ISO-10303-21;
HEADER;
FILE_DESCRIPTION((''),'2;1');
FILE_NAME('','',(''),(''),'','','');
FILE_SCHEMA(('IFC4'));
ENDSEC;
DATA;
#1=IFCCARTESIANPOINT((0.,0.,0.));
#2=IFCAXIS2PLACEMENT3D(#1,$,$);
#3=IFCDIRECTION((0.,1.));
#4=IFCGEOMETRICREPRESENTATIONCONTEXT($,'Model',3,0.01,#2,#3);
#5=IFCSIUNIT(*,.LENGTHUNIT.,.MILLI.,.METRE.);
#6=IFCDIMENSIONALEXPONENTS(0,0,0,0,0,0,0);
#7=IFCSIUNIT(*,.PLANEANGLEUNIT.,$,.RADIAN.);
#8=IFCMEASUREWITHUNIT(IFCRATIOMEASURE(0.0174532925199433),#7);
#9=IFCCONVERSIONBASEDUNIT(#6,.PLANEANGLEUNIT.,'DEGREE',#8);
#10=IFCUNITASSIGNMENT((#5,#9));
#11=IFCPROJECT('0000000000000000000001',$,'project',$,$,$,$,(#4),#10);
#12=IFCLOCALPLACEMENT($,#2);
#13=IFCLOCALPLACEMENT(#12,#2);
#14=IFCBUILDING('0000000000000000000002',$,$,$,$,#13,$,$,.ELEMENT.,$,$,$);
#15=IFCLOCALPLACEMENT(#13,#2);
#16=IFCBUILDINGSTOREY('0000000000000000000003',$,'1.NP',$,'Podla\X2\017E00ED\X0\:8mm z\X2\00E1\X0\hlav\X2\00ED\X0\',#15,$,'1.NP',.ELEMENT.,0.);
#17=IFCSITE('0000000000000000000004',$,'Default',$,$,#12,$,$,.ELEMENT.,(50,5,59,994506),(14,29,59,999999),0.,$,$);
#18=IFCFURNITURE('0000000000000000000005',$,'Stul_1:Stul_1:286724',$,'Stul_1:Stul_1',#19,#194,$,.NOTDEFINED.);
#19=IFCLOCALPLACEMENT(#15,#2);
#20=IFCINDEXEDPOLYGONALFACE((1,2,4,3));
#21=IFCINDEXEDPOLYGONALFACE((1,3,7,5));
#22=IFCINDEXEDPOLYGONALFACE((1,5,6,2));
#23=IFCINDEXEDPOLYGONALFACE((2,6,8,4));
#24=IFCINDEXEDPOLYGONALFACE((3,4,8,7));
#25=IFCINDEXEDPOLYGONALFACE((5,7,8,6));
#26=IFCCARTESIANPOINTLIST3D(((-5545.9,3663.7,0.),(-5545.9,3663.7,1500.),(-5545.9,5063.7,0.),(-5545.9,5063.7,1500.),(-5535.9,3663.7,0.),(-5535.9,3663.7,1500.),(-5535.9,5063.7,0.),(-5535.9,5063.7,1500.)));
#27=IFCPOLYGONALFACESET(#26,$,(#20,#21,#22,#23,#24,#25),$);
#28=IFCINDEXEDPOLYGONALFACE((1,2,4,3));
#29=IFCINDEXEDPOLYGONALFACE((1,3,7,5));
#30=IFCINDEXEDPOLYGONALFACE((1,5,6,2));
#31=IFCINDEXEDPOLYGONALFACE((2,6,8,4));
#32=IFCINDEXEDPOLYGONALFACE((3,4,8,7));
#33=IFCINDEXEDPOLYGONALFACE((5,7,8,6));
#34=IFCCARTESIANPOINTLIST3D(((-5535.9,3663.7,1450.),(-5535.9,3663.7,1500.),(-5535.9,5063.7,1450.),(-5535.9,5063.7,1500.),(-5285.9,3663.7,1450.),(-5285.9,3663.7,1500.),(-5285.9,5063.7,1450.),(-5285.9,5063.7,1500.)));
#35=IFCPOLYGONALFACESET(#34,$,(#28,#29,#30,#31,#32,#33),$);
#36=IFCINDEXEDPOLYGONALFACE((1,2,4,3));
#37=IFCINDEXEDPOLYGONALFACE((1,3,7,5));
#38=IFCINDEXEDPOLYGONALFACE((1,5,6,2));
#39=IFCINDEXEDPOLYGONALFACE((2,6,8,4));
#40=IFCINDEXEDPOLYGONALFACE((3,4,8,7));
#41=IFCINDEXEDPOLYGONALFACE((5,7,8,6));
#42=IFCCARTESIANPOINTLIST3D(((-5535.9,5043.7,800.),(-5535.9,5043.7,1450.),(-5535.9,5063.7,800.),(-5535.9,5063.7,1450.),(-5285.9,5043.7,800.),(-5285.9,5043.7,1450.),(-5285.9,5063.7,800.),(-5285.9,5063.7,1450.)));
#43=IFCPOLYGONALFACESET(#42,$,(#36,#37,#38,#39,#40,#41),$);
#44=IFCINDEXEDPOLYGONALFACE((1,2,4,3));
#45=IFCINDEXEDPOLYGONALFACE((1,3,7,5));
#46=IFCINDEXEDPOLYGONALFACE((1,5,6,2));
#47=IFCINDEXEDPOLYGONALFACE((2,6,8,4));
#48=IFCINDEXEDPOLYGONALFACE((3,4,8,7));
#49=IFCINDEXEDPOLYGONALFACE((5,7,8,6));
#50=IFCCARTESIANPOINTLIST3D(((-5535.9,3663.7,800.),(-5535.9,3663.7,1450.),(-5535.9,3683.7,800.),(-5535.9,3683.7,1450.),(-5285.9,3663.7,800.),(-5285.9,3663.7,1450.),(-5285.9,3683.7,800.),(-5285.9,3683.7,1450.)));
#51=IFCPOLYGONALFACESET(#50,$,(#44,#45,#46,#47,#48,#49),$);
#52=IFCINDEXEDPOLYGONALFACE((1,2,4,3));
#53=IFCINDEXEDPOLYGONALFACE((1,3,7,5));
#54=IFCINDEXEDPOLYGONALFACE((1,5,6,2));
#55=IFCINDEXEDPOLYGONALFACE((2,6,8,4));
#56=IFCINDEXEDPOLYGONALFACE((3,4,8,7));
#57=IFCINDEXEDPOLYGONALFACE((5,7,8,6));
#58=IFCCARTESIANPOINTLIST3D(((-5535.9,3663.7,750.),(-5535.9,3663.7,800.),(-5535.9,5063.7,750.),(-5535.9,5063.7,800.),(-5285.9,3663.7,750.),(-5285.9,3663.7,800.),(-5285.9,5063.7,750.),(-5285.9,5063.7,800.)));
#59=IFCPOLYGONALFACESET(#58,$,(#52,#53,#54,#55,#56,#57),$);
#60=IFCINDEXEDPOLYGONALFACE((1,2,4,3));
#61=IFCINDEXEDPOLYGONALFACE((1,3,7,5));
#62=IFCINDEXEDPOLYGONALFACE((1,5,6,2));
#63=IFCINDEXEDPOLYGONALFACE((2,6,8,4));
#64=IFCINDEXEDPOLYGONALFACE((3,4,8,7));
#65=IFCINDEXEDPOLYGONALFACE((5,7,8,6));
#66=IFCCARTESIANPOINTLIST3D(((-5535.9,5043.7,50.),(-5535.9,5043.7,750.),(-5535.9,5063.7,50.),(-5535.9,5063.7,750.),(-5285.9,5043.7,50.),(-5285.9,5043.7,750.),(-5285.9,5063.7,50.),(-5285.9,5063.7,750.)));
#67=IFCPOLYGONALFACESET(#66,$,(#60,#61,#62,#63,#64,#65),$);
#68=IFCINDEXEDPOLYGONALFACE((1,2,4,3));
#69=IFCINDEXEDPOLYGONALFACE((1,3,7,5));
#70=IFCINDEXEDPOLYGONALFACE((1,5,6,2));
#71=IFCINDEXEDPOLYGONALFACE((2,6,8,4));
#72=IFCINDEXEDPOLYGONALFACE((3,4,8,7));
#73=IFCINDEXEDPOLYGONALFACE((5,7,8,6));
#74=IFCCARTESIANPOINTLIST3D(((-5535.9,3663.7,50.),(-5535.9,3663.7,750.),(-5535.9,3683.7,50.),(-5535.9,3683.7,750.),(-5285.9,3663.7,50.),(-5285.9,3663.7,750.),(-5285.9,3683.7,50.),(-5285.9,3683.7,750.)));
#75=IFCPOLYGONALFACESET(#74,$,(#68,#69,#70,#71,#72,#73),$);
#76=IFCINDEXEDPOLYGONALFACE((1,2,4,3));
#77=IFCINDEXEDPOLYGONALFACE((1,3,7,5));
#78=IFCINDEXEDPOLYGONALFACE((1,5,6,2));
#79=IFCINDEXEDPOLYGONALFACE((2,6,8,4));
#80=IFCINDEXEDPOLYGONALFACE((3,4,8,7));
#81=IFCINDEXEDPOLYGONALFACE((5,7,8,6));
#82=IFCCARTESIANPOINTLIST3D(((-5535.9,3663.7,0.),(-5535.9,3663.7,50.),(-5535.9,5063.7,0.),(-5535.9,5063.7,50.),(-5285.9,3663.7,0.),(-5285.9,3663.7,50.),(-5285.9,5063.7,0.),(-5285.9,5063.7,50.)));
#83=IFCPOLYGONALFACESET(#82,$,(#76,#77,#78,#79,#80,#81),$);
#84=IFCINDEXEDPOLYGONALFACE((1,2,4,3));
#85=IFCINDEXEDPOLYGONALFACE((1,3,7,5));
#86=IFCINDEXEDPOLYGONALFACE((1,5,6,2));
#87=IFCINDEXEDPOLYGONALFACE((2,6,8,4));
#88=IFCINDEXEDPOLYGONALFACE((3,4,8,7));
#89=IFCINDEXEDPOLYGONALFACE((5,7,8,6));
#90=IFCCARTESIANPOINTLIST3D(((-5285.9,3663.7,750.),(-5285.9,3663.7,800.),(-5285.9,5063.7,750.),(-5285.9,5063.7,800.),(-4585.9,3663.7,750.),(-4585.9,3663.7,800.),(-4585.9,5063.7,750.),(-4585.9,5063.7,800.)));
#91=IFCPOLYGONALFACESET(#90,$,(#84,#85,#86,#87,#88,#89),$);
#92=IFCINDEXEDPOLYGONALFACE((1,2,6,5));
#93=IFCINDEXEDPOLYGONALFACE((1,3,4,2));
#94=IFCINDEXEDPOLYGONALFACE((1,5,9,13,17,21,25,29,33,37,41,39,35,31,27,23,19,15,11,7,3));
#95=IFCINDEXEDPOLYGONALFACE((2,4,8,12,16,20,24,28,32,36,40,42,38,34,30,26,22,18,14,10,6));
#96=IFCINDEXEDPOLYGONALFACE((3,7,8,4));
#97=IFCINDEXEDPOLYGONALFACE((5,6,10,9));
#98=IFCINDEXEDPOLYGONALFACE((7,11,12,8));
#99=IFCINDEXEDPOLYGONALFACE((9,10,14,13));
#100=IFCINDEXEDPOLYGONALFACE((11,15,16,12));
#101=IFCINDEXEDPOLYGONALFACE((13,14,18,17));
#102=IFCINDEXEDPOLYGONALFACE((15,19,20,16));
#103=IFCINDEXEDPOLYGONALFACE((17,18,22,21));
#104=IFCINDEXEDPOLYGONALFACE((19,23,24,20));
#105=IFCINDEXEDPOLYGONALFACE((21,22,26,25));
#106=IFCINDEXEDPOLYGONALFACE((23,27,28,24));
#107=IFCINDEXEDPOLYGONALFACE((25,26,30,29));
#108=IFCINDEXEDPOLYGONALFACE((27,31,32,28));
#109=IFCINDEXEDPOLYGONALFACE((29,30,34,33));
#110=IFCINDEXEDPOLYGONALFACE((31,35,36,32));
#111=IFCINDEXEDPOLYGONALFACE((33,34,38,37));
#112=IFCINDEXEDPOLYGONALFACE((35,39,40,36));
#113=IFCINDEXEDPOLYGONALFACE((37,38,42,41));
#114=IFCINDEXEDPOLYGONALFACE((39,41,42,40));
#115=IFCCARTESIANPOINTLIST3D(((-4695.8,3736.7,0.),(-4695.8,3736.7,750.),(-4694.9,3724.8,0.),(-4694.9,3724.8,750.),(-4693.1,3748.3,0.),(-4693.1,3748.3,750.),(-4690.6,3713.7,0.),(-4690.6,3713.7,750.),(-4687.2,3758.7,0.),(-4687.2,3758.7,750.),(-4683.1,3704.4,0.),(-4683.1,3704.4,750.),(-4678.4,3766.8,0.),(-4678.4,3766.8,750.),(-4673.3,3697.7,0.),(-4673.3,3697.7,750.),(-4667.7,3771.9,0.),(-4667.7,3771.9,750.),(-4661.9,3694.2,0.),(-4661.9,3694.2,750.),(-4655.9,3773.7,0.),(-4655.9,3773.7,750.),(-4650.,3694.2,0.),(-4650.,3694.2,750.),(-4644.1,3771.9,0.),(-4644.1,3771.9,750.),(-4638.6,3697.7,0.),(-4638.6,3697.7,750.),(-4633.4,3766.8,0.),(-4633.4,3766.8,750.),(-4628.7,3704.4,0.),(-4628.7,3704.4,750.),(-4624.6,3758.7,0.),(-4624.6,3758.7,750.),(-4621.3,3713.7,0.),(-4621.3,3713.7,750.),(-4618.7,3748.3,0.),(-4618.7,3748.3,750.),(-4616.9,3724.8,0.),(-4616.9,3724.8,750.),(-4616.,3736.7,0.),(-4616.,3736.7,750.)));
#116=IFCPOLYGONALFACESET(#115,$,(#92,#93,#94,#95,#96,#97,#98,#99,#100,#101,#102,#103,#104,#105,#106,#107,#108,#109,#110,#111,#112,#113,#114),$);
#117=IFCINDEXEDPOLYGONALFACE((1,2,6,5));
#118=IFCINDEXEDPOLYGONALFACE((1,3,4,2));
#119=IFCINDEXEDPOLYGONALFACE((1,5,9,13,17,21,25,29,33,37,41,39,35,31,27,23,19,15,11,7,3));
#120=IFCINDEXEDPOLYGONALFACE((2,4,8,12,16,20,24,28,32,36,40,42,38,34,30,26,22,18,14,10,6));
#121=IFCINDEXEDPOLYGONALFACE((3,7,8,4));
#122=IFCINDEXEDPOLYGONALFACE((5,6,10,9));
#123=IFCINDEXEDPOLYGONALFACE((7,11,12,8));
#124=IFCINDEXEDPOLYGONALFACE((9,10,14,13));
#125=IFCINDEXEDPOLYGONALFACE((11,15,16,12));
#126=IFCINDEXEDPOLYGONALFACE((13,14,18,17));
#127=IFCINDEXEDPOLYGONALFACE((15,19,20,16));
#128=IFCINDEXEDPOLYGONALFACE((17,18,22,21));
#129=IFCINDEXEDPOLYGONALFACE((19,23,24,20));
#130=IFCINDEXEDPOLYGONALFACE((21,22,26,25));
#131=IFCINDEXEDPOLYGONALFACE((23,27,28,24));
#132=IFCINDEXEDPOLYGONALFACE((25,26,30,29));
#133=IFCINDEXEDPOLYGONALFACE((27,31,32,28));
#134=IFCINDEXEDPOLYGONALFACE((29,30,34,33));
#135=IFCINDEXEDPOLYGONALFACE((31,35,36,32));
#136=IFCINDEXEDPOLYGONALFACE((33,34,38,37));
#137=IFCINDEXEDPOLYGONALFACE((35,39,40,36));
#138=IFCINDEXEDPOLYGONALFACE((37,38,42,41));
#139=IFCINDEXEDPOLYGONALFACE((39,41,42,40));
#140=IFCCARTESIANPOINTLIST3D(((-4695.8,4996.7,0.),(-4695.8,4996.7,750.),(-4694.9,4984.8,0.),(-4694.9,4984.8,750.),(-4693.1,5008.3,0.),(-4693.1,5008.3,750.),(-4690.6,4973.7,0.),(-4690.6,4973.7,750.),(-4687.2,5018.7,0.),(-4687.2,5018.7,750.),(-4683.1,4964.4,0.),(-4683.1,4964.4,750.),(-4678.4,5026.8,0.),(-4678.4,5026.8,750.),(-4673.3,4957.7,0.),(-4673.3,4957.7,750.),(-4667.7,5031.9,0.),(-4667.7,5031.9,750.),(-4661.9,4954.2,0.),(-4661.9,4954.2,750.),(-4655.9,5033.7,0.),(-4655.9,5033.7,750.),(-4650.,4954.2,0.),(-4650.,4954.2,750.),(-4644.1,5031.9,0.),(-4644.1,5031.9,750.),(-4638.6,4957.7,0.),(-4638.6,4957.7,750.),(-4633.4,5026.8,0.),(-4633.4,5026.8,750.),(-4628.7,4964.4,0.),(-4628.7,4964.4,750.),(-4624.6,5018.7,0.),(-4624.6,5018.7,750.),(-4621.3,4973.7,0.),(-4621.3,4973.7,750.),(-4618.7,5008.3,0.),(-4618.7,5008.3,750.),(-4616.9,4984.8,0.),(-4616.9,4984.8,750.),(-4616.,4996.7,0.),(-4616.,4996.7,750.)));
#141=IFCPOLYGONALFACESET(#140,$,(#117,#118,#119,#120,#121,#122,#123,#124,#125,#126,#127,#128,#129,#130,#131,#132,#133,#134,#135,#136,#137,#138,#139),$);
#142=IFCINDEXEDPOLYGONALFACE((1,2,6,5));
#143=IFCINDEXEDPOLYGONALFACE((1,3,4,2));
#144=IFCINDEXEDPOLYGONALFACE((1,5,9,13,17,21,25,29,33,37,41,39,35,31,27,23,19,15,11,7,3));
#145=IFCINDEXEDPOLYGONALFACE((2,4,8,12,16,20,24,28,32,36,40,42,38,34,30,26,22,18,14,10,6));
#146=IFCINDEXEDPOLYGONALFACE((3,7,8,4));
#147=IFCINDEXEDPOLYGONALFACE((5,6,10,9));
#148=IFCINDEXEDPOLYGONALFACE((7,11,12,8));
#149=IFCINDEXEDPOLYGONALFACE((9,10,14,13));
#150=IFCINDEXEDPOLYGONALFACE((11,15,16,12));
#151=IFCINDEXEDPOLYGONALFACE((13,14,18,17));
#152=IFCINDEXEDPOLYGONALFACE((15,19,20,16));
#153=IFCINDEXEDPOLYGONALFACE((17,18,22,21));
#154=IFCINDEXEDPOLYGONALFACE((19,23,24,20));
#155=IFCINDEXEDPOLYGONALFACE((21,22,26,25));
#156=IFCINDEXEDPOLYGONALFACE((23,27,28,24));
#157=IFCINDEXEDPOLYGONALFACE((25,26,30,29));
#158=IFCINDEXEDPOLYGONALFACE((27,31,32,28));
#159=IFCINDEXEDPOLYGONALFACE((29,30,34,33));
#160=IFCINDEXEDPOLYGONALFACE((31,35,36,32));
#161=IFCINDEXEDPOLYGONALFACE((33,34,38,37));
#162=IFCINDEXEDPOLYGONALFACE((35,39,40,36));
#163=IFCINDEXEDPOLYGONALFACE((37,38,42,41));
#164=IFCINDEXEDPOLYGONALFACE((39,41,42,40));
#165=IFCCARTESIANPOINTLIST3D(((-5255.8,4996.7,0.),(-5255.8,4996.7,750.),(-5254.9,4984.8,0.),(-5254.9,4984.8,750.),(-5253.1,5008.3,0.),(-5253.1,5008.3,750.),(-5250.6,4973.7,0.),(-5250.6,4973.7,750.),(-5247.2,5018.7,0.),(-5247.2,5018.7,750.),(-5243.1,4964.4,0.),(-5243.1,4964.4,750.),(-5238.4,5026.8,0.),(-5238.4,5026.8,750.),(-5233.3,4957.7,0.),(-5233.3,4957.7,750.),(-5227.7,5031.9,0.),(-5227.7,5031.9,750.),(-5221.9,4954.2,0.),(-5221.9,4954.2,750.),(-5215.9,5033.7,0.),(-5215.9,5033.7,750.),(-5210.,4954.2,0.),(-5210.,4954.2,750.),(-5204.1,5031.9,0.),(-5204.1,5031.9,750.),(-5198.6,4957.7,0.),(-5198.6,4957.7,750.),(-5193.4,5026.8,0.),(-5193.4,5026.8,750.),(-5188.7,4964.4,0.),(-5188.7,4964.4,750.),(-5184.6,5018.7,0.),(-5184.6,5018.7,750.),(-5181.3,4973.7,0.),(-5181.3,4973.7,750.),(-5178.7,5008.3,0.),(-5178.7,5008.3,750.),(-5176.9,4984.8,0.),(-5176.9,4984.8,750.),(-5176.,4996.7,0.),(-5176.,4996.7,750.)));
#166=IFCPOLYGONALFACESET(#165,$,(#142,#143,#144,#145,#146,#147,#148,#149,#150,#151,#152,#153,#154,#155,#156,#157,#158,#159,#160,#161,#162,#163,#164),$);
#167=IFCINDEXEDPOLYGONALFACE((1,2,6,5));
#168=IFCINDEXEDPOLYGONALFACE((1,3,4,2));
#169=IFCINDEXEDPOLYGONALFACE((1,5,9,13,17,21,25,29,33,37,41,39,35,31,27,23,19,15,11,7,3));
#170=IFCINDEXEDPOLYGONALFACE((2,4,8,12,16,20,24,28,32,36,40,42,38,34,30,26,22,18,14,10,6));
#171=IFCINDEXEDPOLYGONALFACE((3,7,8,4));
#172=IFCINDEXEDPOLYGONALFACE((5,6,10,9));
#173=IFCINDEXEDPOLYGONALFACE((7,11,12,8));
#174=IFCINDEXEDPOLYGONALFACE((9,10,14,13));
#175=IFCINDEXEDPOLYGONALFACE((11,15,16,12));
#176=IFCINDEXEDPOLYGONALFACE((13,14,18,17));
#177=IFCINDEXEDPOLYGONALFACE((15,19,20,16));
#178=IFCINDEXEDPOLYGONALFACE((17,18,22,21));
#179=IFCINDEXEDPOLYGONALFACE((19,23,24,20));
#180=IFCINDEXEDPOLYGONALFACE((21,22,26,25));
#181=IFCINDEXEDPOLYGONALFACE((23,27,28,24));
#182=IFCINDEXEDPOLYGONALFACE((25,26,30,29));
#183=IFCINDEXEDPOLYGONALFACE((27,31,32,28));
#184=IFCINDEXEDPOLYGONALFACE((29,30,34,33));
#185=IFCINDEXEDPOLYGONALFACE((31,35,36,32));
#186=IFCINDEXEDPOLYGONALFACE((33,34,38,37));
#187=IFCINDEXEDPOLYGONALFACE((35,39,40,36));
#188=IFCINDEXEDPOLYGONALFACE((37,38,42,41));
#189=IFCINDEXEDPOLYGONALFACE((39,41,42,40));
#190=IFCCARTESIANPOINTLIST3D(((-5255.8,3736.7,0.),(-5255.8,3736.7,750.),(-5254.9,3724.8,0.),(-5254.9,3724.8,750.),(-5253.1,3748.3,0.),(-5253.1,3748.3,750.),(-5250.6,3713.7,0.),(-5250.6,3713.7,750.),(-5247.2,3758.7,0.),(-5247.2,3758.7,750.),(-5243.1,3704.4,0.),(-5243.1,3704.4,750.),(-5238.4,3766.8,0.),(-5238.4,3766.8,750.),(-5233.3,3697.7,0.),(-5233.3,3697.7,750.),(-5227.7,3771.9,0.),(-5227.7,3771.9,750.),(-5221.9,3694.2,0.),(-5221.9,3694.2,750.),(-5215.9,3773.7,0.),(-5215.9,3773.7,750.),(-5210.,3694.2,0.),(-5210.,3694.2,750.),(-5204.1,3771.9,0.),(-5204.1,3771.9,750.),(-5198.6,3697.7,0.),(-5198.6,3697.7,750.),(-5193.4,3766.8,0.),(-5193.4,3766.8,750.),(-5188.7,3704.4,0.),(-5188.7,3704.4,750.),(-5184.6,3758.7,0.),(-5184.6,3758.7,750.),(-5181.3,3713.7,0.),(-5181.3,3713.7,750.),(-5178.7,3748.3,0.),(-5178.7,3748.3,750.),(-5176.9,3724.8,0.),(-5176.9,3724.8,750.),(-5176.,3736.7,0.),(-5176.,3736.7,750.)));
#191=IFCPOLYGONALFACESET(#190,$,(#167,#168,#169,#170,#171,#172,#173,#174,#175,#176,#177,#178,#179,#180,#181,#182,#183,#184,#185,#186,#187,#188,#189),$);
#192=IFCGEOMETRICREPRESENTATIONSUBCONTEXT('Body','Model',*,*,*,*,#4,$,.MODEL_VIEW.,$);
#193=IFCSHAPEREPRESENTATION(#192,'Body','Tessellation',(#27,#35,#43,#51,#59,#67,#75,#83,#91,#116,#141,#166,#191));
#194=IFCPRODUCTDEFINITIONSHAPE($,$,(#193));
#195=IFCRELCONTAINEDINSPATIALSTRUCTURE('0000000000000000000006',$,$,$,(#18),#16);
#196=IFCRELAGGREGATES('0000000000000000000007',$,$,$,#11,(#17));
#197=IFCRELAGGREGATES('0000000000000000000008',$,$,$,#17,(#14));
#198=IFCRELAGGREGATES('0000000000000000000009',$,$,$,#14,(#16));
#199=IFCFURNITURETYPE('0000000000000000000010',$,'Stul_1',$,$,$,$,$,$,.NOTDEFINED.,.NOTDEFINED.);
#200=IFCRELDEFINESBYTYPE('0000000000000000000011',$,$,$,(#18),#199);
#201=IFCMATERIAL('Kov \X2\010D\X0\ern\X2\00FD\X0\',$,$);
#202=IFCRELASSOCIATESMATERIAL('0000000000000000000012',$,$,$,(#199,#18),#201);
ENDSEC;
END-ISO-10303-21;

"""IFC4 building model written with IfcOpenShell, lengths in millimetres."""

from ifc_helpers import new_model, entity, si_unit, converted_unit, direction, frame, frame_2d, origin, origin_2d_with_axis, place, context, subcontext, project, spatial, rectangle, circle, extrude, source, transform, mapped, material, type_object, type_shapes, element, save


model = new_model("IFC4")

# Units and contexts
model_context = context("Model", 3, precision=0.01, world=origin(), true_north=direction((0.0, 1.0)))
body_context = subcontext(model_context, "Body", "Model", "MODEL_VIEW")
ifc_project = project(units=[si_unit("LENGTHUNIT", "METRE", prefix="MILLI"), converted_unit("PLANEANGLEUNIT", "DEGREE", entity("IfcRatioMeasure", 0.0174532925199433), si_unit("PLANEANGLEUNIT", "RADIAN"), dimensions=[0, 0, 0, 0, 0, 0, 0])], contexts=[model_context])

# Site, building, storey
site_placement = place(None, origin())
site = spatial("IfcSite", under=ifc_project, at=site_placement, Name="Default", CompositionType="ELEMENT", RefLatitude=(50, 5, 59, 994506), RefLongitude=(14, 29, 59, 999999), RefElevation=0.0)
building_placement = place(site_placement, origin())
building = spatial("IfcBuilding", under=site, at=building_placement, CompositionType="ELEMENT")
storey_placement = place(building_placement, origin())
storey = spatial("IfcBuildingStorey", under=building, at=storey_placement, Name="1.NP", ObjectType="Podlaží:8mm záhlaví", LongName="1.NP", CompositionType="ELEMENT", Elevation=0.0)

# Furniture
ifc_material_1 = material(Name="Kov černý")
furniture_type = type_object("IfcFurnitureType", Name="Stul_1", AssemblyPlace="NOTDEFINED", PredefinedType="NOTDEFINED", material=ifc_material_1)
shared_shape_1 = source(origin(), body_context, "Body", "SweptSolid", [
    extrude(rectangle(XDim=1400.0, YDim=10.0, at=origin_2d_with_axis()), frame((0.0, 605.0, 0.0), z_axis=(0.0, 0.0, 1.0), x_axis=(-1.0, 0.0, 0.0)), (0.0, 0.0, 1.0), 1500.0),
    extrude(rectangle(XDim=1400.0, YDim=250.0, at=frame_2d((0.0, 0.0), x_axis=(1.0, 0.0))), frame((0.0, 475.0, 1450.0), z_axis=(0.0, 0.0, 1.0), x_axis=(-1.0, 0.0, 0.0)), (0.0, 0.0, 1.0), 50.0),
    extrude(rectangle(XDim=20.0, YDim=250.0, at=origin_2d_with_axis()), frame((690.0, 475.0, 800.0), z_axis=(0.0, 0.0, 1.0), x_axis=(-1.0, 0.0, 0.0)), (0.0, 0.0, 1.0), 650.0),
    extrude(rectangle(XDim=20.0, YDim=250.0, at=frame_2d((0.0, 0.0), x_axis=(1.0, 0.0))), frame((-690.0, 475.0, 800.0), z_axis=(0.0, 0.0, 1.0), x_axis=(-1.0, 0.0, 0.0)), (0.0, 0.0, 1.0), 650.0),
    extrude(rectangle(XDim=1400.0, YDim=250.0, at=origin_2d_with_axis()), frame((0.0, 475.0, 750.0), z_axis=(0.0, 0.0, 1.0), x_axis=(-1.0, 0.0, 0.0)), (0.0, 0.0, 1.0), 50.0),
    extrude(rectangle(XDim=20.0, YDim=250.0, at=origin_2d_with_axis()), frame((690.0, 475.0, 50.0), z_axis=(0.0, 0.0, 1.0), x_axis=(-1.0, 0.0, 0.0)), (0.0, 0.0, 1.0), 700.0),
    extrude(rectangle(XDim=20.0, YDim=250.0, at=frame_2d((0.0, 0.0), x_axis=(1.0, 0.0))), frame((-690.0, 475.0, 50.0), z_axis=(0.0, 0.0, 1.0), x_axis=(-1.0, 0.0, 0.0)), (0.0, 0.0, 1.0), 700.0),
    extrude(rectangle(XDim=1400.0, YDim=250.0, at=origin_2d_with_axis()), frame((0.0, 475.0, 0.0), z_axis=(0.0, 0.0, 1.0), x_axis=(-1.0, 0.0, 0.0)), (0.0, 0.0, 1.0), 50.0),
    extrude(rectangle(XDim=1400.0, YDim=700.0, at=origin_2d_with_axis()), frame((0.0, 0.0, 750.0), z_axis=(0.0, 0.0, 1.0), x_axis=(-1.0, 0.0, 0.0)), (0.0, 0.0, 1.0), 50.0),
    extrude(circle(Radius=40.0, at=frame_2d((0.0, 0.0), x_axis=(1.0, 0.0))), frame((-630.0, -280.0, 0.0)), (0.0, 0.0, 1.0), 750.0),
    extrude(circle(Radius=40.0, at=frame_2d((0.0, 0.0), x_axis=(1.0, 0.0))), frame((630.0, -280.0, 0.0)), (0.0, 0.0, 1.0), 750.0),
    extrude(circle(Radius=40.0, at=frame_2d((0.0, 0.0), x_axis=(1.0, 0.0))), frame((630.0, 280.0, 0.0)), (0.0, 0.0, 1.0), 750.0),
    extrude(circle(Radius=40.0, at=frame_2d((0.0, 0.0), x_axis=(1.0, 0.0))), frame((-630.0, 280.0, 0.0)), (0.0, 0.0, 1.0), 750.0),
])
type_shapes(furniture_type, [shared_shape_1])
for number, where, z_axis, x_axis, name in (
    (1, (-4935.9, 4363.7, 0.0), (0.0, 0.0, 1.0), (0.0, 1.0, 0.0), "Stul_1:Stul_1:286724"),
):
    element("IfcFurniture", number, at=place(storey_placement, frame(where, z_axis=z_axis, x_axis=x_axis)), inside=storey, type_object=furniture_type, material=ifc_material_1, Name=name, ObjectType="Stul_1:Stul_1", PredefinedType="NOTDEFINED", context=body_context, shape_type="MappedRepresentation", body=[
        mapped(shared_shape_1, transform((0.0, 0.0, 0.0), scale=1.0)),
    ])

save(model, "model.ifc")
